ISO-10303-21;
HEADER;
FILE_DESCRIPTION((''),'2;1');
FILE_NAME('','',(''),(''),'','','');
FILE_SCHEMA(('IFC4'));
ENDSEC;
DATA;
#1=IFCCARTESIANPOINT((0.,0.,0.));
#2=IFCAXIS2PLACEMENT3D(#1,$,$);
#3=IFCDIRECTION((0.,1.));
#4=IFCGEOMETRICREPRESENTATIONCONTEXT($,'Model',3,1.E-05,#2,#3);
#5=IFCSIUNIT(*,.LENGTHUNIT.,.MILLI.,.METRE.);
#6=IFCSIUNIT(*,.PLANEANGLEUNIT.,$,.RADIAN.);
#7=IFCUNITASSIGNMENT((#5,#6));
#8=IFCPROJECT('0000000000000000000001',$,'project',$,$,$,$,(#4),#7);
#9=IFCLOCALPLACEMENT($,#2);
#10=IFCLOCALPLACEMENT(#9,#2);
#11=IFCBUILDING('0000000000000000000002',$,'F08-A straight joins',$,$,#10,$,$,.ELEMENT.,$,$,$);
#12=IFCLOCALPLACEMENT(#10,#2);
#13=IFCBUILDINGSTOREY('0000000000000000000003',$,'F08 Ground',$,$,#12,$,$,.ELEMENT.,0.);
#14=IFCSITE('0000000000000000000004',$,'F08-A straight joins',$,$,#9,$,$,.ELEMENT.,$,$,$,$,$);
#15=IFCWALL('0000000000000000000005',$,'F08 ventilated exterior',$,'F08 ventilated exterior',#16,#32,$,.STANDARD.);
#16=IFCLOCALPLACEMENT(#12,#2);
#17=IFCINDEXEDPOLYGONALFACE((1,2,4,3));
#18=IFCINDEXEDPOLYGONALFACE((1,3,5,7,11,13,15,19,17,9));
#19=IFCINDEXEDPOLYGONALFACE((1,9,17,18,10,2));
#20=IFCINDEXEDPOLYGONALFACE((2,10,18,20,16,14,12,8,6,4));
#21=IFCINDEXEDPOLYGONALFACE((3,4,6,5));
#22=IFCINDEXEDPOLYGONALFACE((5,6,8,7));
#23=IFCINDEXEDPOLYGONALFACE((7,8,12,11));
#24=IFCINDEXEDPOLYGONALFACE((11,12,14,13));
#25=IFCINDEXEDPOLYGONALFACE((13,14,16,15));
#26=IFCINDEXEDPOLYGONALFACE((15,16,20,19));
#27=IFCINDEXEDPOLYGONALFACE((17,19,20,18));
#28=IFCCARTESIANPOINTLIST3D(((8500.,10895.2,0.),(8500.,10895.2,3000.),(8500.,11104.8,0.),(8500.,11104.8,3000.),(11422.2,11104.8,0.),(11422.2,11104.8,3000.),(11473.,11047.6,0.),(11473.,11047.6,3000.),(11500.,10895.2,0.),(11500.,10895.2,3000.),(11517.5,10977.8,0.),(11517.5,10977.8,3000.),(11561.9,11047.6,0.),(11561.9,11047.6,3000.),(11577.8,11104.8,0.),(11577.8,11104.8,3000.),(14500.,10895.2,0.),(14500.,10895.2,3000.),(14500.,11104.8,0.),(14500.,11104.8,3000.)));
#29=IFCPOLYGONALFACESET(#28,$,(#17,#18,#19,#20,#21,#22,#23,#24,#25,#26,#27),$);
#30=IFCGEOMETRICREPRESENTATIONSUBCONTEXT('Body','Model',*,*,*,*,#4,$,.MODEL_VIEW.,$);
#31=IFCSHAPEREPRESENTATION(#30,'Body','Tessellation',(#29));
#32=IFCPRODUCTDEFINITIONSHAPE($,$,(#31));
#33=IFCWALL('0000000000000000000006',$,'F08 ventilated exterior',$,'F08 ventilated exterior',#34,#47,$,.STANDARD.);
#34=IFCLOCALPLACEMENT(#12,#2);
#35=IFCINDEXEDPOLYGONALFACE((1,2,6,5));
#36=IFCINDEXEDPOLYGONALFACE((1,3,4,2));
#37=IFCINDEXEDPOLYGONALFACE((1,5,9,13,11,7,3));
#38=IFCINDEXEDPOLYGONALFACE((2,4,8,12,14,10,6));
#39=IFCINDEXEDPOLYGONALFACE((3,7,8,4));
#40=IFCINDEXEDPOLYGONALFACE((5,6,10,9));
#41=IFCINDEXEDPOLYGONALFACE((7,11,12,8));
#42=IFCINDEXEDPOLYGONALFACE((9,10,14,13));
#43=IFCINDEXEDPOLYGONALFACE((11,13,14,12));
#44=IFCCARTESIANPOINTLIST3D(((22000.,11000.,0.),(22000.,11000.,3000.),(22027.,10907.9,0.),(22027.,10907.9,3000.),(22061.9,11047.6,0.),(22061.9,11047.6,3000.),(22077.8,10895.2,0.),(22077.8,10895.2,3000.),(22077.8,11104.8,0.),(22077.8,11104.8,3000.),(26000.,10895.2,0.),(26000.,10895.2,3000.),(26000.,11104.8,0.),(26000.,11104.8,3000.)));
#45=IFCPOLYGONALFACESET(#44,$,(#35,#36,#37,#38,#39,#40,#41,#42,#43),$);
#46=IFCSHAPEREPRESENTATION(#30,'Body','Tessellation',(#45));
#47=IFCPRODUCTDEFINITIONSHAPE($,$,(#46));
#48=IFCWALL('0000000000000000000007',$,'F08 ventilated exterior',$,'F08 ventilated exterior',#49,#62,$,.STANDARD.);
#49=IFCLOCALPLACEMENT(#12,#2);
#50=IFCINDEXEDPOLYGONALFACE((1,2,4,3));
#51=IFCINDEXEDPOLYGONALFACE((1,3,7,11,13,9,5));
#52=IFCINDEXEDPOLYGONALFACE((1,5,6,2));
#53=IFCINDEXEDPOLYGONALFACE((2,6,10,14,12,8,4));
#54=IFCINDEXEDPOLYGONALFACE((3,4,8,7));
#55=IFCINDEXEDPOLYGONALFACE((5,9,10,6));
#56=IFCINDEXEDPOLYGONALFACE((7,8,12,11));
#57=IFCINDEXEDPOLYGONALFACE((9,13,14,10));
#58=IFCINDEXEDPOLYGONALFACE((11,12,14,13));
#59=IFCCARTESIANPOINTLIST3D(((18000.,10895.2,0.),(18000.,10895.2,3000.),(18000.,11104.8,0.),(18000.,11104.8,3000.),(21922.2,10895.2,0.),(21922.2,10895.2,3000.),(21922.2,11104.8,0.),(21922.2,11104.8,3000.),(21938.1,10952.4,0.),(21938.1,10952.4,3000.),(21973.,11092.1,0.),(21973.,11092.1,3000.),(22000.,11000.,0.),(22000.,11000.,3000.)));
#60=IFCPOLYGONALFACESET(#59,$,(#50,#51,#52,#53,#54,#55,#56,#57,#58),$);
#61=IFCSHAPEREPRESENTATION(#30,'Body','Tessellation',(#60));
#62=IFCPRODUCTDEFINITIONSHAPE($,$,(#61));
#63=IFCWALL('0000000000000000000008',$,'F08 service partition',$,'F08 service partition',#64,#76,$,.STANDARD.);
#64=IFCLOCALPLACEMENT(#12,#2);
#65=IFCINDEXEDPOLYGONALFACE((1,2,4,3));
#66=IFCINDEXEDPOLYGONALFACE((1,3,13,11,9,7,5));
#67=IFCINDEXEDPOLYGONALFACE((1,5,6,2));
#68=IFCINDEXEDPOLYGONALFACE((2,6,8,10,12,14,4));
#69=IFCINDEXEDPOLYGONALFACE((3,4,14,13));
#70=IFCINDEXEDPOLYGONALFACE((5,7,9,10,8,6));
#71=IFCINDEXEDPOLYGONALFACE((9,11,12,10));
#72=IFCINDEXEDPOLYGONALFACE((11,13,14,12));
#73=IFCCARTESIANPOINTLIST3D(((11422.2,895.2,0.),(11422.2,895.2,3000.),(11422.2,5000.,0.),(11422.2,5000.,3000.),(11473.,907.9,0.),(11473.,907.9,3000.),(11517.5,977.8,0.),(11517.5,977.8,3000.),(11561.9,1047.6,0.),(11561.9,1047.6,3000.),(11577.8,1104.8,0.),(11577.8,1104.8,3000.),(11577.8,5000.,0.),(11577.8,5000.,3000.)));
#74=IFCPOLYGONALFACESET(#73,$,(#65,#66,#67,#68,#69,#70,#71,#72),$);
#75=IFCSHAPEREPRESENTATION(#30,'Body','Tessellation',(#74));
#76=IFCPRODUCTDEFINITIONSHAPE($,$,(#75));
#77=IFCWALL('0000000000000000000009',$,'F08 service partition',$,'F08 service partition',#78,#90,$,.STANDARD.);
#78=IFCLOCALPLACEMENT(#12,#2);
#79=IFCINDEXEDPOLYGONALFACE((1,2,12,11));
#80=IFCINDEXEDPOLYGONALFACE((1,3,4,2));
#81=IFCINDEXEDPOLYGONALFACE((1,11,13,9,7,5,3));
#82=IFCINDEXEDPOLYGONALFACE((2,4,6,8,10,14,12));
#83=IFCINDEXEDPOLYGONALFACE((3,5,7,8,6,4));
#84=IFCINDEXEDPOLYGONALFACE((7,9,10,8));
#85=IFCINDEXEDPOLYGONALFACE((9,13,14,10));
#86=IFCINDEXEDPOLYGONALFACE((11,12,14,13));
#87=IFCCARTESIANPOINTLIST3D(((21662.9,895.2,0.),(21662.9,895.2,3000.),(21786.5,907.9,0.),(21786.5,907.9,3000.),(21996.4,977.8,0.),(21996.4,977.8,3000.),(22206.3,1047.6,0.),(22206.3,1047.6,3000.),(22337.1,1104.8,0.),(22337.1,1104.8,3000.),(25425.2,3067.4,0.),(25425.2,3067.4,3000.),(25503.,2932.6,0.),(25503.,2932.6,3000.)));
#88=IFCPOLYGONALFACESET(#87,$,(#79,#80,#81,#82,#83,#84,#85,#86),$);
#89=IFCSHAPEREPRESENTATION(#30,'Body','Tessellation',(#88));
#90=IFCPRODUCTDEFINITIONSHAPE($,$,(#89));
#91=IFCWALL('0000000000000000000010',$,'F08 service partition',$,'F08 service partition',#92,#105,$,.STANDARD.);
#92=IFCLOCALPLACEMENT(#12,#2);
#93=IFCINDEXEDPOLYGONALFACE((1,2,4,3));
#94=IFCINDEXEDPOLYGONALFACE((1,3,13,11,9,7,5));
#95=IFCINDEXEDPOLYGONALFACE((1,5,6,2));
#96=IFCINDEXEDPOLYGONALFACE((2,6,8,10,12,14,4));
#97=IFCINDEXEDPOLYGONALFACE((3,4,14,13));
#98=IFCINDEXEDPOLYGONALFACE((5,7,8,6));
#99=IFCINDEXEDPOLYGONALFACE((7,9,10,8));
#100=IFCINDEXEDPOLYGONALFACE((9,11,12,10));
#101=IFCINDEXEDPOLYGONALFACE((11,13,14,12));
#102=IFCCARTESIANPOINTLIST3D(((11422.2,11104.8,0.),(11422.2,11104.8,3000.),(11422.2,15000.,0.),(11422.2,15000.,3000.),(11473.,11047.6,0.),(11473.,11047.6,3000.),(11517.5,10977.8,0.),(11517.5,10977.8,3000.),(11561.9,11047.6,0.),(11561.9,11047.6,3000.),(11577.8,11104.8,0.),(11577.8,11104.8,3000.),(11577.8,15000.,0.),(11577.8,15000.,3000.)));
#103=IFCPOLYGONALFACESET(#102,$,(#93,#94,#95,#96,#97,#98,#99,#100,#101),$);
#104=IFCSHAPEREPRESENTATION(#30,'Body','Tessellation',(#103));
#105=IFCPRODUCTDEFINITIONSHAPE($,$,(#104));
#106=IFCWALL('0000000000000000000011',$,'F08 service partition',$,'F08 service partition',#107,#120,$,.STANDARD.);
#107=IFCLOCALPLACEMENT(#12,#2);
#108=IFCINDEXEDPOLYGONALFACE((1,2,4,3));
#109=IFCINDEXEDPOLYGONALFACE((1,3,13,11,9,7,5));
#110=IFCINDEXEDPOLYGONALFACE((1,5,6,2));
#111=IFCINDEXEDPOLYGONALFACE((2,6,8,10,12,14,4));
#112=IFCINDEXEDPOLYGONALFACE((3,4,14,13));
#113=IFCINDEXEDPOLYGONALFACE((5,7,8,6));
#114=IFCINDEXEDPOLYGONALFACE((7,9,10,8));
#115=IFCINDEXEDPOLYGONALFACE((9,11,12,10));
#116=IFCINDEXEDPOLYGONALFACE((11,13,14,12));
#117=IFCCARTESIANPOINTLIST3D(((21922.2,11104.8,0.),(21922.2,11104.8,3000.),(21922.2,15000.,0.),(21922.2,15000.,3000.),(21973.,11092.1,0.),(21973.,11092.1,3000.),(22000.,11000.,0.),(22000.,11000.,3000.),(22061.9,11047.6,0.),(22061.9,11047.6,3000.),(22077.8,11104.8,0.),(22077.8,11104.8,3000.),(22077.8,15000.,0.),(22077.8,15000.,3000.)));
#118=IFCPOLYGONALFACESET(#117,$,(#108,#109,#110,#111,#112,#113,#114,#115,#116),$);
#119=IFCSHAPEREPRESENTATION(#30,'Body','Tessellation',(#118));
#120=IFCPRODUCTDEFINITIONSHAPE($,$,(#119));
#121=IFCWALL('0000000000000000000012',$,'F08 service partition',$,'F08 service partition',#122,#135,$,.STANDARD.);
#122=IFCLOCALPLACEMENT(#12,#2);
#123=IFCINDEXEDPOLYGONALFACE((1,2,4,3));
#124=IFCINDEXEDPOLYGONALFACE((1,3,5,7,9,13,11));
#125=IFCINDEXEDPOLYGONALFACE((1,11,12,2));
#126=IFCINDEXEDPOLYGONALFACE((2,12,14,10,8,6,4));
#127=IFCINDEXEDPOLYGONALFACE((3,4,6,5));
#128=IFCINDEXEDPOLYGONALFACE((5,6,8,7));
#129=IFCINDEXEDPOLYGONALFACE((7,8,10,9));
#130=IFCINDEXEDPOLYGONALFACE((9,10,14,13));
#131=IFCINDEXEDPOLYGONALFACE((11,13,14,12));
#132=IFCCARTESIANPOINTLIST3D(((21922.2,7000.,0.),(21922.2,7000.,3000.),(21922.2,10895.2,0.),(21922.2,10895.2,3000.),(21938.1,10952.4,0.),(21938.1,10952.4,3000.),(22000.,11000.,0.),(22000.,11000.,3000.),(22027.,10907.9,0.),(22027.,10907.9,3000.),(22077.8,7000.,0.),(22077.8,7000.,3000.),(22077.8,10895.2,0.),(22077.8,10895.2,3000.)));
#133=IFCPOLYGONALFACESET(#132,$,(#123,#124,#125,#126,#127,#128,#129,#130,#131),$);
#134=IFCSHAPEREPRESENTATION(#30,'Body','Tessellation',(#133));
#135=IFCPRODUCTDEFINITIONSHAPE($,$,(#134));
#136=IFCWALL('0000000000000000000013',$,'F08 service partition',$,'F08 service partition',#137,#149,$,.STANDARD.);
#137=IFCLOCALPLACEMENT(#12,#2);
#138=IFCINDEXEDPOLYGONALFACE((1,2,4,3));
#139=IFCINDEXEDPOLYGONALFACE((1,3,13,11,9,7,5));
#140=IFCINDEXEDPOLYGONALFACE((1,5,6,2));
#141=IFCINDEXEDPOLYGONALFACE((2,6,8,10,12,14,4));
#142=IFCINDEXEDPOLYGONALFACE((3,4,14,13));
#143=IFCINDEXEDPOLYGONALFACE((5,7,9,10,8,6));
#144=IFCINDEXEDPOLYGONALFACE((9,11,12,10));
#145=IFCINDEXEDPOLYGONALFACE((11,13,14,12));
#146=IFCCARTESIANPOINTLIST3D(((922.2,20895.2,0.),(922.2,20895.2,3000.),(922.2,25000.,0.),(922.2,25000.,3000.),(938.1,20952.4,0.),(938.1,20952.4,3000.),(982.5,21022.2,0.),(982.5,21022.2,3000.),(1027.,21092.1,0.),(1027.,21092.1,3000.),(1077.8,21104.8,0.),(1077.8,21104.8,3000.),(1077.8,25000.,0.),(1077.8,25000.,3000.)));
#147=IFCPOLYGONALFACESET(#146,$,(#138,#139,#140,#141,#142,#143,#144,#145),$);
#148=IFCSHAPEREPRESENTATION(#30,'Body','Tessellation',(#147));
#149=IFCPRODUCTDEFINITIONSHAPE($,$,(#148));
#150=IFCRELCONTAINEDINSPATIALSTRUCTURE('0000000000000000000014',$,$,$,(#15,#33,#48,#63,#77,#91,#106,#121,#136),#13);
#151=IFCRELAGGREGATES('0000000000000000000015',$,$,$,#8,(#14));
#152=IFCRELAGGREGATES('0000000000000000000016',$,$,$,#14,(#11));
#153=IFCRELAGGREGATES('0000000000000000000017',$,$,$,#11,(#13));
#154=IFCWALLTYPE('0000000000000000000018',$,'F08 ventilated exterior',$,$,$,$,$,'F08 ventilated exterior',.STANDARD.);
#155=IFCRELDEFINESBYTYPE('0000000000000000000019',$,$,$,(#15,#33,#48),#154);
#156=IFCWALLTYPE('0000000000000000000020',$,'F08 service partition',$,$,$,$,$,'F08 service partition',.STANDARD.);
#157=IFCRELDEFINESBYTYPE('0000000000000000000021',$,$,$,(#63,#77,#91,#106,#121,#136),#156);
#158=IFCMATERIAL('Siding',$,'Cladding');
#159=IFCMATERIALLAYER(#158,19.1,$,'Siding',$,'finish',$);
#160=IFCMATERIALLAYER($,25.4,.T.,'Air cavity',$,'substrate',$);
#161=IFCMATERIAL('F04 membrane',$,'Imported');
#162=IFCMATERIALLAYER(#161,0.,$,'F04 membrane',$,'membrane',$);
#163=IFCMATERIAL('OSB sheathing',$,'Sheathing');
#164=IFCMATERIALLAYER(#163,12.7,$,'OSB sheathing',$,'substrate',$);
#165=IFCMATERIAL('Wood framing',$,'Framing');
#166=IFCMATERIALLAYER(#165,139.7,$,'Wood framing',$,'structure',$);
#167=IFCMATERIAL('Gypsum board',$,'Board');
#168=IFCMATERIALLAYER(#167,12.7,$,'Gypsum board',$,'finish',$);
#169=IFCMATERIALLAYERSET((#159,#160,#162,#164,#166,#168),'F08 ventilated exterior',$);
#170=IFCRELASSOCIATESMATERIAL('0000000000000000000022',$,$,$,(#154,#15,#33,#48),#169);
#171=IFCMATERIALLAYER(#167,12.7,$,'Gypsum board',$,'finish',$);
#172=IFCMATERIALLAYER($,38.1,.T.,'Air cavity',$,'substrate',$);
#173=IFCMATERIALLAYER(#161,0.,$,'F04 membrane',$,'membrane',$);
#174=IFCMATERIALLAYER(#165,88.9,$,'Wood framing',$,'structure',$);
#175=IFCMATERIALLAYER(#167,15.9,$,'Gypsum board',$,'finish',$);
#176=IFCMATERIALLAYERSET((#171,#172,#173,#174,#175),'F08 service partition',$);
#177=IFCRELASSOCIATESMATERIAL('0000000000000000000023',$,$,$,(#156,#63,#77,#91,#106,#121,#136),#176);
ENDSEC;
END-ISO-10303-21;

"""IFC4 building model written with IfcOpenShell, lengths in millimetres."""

from ifc_helpers import new_model, si_unit, direction, frame, origin, place, context, subcontext, project, spatial, polyline, outline, extrude, material, layer, layer_set, layer_usage, type_object, element, save


model = new_model("IFC4")

# Units and contexts
model_context = context("Model", 3, precision=1e-05, world=origin(), true_north=direction((0.0, 1.0)))
body_context = subcontext(model_context, "Body", "Model", "MODEL_VIEW")
ifc_project = project(units=[si_unit("LENGTHUNIT", "METRE", prefix="MILLI"), si_unit("PLANEANGLEUNIT", "RADIAN")], contexts=[model_context])

# Site, building, storey
site_placement = place(None, origin())
site = spatial("IfcSite", under=ifc_project, at=site_placement, Name="F08-A straight joins", CompositionType="ELEMENT")
building_placement = place(site_placement, origin())
building = spatial("IfcBuilding", under=site, at=building_placement, Name="F08-A straight joins", CompositionType="ELEMENT")
storey_placement = place(building_placement, origin())
storey = spatial("IfcBuildingStorey", under=building, at=storey_placement, Name="F08 Ground", CompositionType="ELEMENT", Elevation=0.0)

# Walls
ifc_material_1 = material(Name="Siding", Category="Cladding")
ifc_layer_1 = layer(ifc_material_1, 19.1, Name="Siding", Category="finish")
ifc_layer_2 = layer(None, 25.4, ventilated=True, Name="Air cavity", Category="substrate")
ifc_material_2 = material(Name="F04 membrane", Category="Imported")
ifc_layer_3 = layer(ifc_material_2, 0.0, Name="F04 membrane", Category="membrane")
ifc_material_3 = material(Name="OSB sheathing", Category="Sheathing")
ifc_layer_4 = layer(ifc_material_3, 12.7, Name="OSB sheathing", Category="substrate")
ifc_material_4 = material(Name="Wood framing", Category="Framing")
ifc_layer_5 = layer(ifc_material_4, 139.7, Name="Wood framing", Category="structure")
ifc_material_5 = material(Name="Gypsum board", Category="Board")
ifc_layer_6 = layer(ifc_material_5, 12.7, Name="Gypsum board", Category="finish")
ifc_layer_set_1 = layer_set([ifc_layer_1, ifc_layer_2, ifc_layer_3, ifc_layer_4, ifc_layer_5, ifc_layer_6], Name="F08 ventilated exterior")
wall_type_1 = type_object("IfcWallType", Name="F08 ventilated exterior", ElementType="F08 ventilated exterior", PredefinedType="STANDARD", material=ifc_layer_set_1)
ifc_layer_usage_1 = layer_usage(ifc_layer_set_1, "AXIS2", "NEGATIVE", 104.8)
wall_1_placement = place(storey_placement, frame((8500.0, 11000.0, 0.0), z_axis=(0.0, 0.0, 1.0), x_axis=(1.0, 0.0, 0.0)))
element("IfcWall", 1, at=wall_1_placement, inside=storey, type_object=wall_type_1, material=ifc_layer_usage_1, Name="F08 ventilated exterior", ObjectType="F08 ventilated exterior", PredefinedType="STANDARD", context=body_context, shape_type="SweptSolid", body=[
    extrude(outline(polyline([(0.0, -104.8), (3000.0, -104.8), (6000.0, -104.8), (6000.0, 104.8), (3077.8, 104.8), (3061.9, 47.6), (3017.5, -22.2), (2973.0, 47.6), (2922.2, 104.8), (0.0, 104.8), (0.0, -104.8)])), origin(), (0.0, 0.0, 1.0), 3000.0),
])
ifc_layer_usage_2 = layer_usage(ifc_layer_set_1, "AXIS2", "NEGATIVE", 104.8)
wall_2_placement = place(storey_placement, frame((22000.0, 11000.0, 0.0), z_axis=(0.0, 0.0, 1.0), x_axis=(1.0, 0.0, 0.0)))
element("IfcWall", 2, at=wall_2_placement, inside=storey, type_object=wall_type_1, material=ifc_layer_usage_2, Name="F08 ventilated exterior", ObjectType="F08 ventilated exterior", PredefinedType="STANDARD", context=body_context, shape_type="SweptSolid", body=[
    extrude(outline(polyline([(77.8, -104.8), (4000.0, -104.8), (4000.0, 104.8), (77.8, 104.8), (61.9, 47.6), (0.0, 0.0), (27.0, -92.1), (77.8, -104.8)])), origin(), (0.0, 0.0, 1.0), 3000.0),
])
ifc_layer_usage_3 = layer_usage(ifc_layer_set_1, "AXIS2", "NEGATIVE", 104.8)
wall_3_placement = place(storey_placement, frame((22000.0, 11000.0, 0.0), z_axis=(0.0, 0.0, 1.0), x_axis=(-1.0, 0.0, 0.0)))
element("IfcWall", 3, at=wall_3_placement, inside=storey, type_object=wall_type_1, material=ifc_layer_usage_3, Name="F08 ventilated exterior", ObjectType="F08 ventilated exterior", PredefinedType="STANDARD", context=body_context, shape_type="SweptSolid", body=[
    extrude(outline(polyline([(77.8, -104.8), (4000.0, -104.8), (4000.0, 104.8), (77.8, 104.8), (61.9, 47.6), (0.0, 0.0), (27.0, -92.1), (77.8, -104.8)])), origin(), (0.0, 0.0, 1.0), 3000.0),
])

# Walls
ifc_layer_7 = layer(ifc_material_5, 12.7, Name="Gypsum board", Category="finish")
ifc_layer_8 = layer(None, 38.1, ventilated=True, Name="Air cavity", Category="substrate")
ifc_layer_9 = layer(ifc_material_2, 0.0, Name="F04 membrane", Category="membrane")
ifc_layer_10 = layer(ifc_material_4, 88.9, Name="Wood framing", Category="structure")
ifc_layer_11 = layer(ifc_material_5, 15.9, Name="Gypsum board", Category="finish")
ifc_layer_set_2 = layer_set([ifc_layer_7, ifc_layer_8, ifc_layer_9, ifc_layer_10, ifc_layer_11], Name="F08 service partition")
ifc_layer_usage_4 = layer_usage(ifc_layer_set_2, "AXIS2", "NEGATIVE", 77.8)
wall_type_2 = type_object("IfcWallType", Name="F08 service partition", ElementType="F08 service partition", PredefinedType="STANDARD", material=ifc_layer_set_2)
wall_4_placement = place(storey_placement, frame((11500.0, 1000.0, 0.0), z_axis=(0.0, 0.0, 1.0), x_axis=(0.0, 1.0, 0.0)))
element("IfcWall", 4, at=wall_4_placement, inside=storey, type_object=wall_type_2, material=ifc_layer_usage_4, Name="F08 service partition", ObjectType="F08 service partition", PredefinedType="STANDARD", context=body_context, shape_type="SweptSolid", body=[
    extrude(outline(polyline([(104.8, -77.8), (4000.0, -77.8), (4000.0, 77.8), (-104.8, 77.8), (-92.1, 27.0), (-22.2, -17.5), (47.6, -61.9), (104.8, -77.8)])), origin(), (0.0, 0.0, 1.0), 3000.0),
])
ifc_layer_usage_5 = layer_usage(ifc_layer_set_2, "AXIS2", "NEGATIVE", 77.8)
wall_5_placement = place(storey_placement, frame((22000.0, 1000.0, 0.0), z_axis=(0.0, 0.0, 1.0), x_axis=(0.866025, 0.5, 0.0)))
element("IfcWall", 5, at=wall_5_placement, inside=storey, type_object=wall_type_2, material=ifc_layer_usage_5, Name="F08 service partition", ObjectType="F08 service partition", PredefinedType="STANDARD", context=body_context, shape_type="SweptSolid", body=[
    extrude(outline(polyline([(344.3, -77.8), (4000.0, -77.8), (4000.0, 77.8), (-344.3, 77.8), (-230.9, 27.0), (-14.2, -17.5), (202.5, -61.9), (344.3, -77.8)])), origin(), (0.0, 0.0, 1.0), 3000.0),
])
ifc_layer_usage_6 = layer_usage(ifc_layer_set_2, "AXIS2", "NEGATIVE", 77.8)
wall_6_placement = place(storey_placement, frame((11500.0, 11000.0, 0.0), z_axis=(0.0, 0.0, 1.0), x_axis=(0.0, 1.0, 0.0)))
element("IfcWall", 6, at=wall_6_placement, inside=storey, type_object=wall_type_2, material=ifc_layer_usage_6, Name="F08 service partition", ObjectType="F08 service partition", PredefinedType="STANDARD", context=body_context, shape_type="SweptSolid", body=[
    extrude(outline(polyline([(104.8, -77.8), (4000.0, -77.8), (4000.0, 77.8), (104.8, 77.8), (47.6, 27.0), (-22.2, -17.5), (47.6, -61.9), (104.8, -77.8)])), origin(), (0.0, 0.0, 1.0), 3000.0),
])
ifc_layer_usage_7 = layer_usage(ifc_layer_set_2, "AXIS2", "NEGATIVE", 77.8)
wall_7_placement = place(storey_placement, frame((22000.0, 11000.0, 0.0), z_axis=(0.0, 0.0, 1.0), x_axis=(0.0, 1.0, 0.0)))
element("IfcWall", 7, at=wall_7_placement, inside=storey, type_object=wall_type_2, material=ifc_layer_usage_7, Name="F08 service partition", ObjectType="F08 service partition", PredefinedType="STANDARD", context=body_context, shape_type="SweptSolid", body=[
    extrude(outline(polyline([(104.8, -77.8), (4000.0, -77.8), (4000.0, 77.8), (104.8, 77.8), (92.1, 27.0), (0.0, 0.0), (47.6, -61.9), (104.8, -77.8)])), origin(), (0.0, 0.0, 1.0), 3000.0),
])
ifc_layer_usage_8 = layer_usage(ifc_layer_set_2, "AXIS2", "NEGATIVE", 77.8)
wall_8_placement = place(storey_placement, frame((22000.0, 11000.0, 0.0), z_axis=(0.0, 0.0, 1.0), x_axis=(0.0, -1.0, 0.0)))
element("IfcWall", 8, at=wall_8_placement, inside=storey, type_object=wall_type_2, material=ifc_layer_usage_8, Name="F08 service partition", ObjectType="F08 service partition", PredefinedType="STANDARD", context=body_context, shape_type="SweptSolid", body=[
    extrude(outline(polyline([(104.8, -77.8), (4000.0, -77.8), (4000.0, 77.8), (104.8, 77.8), (92.1, 27.0), (0.0, 0.0), (47.6, -61.9), (104.8, -77.8)])), origin(), (0.0, 0.0, 1.0), 3000.0),
])
ifc_layer_usage_9 = layer_usage(ifc_layer_set_2, "AXIS2", "POSITIVE", -77.8)
wall_9_placement = place(storey_placement, frame((1000.0, 21000.0, 0.0), z_axis=(0.0, 0.0, 1.0), x_axis=(0.0, 1.0, 0.0)))
element("IfcWall", 9, at=wall_9_placement, inside=storey, type_object=wall_type_2, material=ifc_layer_usage_9, Name="F08 service partition", ObjectType="F08 service partition", PredefinedType="STANDARD", context=body_context, shape_type="SweptSolid", body=[
    extrude(outline(polyline([(104.8, -77.8), (4000.0, -77.8), (4000.0, 77.8), (-104.8, 77.8), (-47.6, 61.9), (22.2, 17.5), (92.1, -27.0), (104.8, -77.8)])), origin(), (0.0, 0.0, 1.0), 3000.0),
])

save(model, "model.ifc")
